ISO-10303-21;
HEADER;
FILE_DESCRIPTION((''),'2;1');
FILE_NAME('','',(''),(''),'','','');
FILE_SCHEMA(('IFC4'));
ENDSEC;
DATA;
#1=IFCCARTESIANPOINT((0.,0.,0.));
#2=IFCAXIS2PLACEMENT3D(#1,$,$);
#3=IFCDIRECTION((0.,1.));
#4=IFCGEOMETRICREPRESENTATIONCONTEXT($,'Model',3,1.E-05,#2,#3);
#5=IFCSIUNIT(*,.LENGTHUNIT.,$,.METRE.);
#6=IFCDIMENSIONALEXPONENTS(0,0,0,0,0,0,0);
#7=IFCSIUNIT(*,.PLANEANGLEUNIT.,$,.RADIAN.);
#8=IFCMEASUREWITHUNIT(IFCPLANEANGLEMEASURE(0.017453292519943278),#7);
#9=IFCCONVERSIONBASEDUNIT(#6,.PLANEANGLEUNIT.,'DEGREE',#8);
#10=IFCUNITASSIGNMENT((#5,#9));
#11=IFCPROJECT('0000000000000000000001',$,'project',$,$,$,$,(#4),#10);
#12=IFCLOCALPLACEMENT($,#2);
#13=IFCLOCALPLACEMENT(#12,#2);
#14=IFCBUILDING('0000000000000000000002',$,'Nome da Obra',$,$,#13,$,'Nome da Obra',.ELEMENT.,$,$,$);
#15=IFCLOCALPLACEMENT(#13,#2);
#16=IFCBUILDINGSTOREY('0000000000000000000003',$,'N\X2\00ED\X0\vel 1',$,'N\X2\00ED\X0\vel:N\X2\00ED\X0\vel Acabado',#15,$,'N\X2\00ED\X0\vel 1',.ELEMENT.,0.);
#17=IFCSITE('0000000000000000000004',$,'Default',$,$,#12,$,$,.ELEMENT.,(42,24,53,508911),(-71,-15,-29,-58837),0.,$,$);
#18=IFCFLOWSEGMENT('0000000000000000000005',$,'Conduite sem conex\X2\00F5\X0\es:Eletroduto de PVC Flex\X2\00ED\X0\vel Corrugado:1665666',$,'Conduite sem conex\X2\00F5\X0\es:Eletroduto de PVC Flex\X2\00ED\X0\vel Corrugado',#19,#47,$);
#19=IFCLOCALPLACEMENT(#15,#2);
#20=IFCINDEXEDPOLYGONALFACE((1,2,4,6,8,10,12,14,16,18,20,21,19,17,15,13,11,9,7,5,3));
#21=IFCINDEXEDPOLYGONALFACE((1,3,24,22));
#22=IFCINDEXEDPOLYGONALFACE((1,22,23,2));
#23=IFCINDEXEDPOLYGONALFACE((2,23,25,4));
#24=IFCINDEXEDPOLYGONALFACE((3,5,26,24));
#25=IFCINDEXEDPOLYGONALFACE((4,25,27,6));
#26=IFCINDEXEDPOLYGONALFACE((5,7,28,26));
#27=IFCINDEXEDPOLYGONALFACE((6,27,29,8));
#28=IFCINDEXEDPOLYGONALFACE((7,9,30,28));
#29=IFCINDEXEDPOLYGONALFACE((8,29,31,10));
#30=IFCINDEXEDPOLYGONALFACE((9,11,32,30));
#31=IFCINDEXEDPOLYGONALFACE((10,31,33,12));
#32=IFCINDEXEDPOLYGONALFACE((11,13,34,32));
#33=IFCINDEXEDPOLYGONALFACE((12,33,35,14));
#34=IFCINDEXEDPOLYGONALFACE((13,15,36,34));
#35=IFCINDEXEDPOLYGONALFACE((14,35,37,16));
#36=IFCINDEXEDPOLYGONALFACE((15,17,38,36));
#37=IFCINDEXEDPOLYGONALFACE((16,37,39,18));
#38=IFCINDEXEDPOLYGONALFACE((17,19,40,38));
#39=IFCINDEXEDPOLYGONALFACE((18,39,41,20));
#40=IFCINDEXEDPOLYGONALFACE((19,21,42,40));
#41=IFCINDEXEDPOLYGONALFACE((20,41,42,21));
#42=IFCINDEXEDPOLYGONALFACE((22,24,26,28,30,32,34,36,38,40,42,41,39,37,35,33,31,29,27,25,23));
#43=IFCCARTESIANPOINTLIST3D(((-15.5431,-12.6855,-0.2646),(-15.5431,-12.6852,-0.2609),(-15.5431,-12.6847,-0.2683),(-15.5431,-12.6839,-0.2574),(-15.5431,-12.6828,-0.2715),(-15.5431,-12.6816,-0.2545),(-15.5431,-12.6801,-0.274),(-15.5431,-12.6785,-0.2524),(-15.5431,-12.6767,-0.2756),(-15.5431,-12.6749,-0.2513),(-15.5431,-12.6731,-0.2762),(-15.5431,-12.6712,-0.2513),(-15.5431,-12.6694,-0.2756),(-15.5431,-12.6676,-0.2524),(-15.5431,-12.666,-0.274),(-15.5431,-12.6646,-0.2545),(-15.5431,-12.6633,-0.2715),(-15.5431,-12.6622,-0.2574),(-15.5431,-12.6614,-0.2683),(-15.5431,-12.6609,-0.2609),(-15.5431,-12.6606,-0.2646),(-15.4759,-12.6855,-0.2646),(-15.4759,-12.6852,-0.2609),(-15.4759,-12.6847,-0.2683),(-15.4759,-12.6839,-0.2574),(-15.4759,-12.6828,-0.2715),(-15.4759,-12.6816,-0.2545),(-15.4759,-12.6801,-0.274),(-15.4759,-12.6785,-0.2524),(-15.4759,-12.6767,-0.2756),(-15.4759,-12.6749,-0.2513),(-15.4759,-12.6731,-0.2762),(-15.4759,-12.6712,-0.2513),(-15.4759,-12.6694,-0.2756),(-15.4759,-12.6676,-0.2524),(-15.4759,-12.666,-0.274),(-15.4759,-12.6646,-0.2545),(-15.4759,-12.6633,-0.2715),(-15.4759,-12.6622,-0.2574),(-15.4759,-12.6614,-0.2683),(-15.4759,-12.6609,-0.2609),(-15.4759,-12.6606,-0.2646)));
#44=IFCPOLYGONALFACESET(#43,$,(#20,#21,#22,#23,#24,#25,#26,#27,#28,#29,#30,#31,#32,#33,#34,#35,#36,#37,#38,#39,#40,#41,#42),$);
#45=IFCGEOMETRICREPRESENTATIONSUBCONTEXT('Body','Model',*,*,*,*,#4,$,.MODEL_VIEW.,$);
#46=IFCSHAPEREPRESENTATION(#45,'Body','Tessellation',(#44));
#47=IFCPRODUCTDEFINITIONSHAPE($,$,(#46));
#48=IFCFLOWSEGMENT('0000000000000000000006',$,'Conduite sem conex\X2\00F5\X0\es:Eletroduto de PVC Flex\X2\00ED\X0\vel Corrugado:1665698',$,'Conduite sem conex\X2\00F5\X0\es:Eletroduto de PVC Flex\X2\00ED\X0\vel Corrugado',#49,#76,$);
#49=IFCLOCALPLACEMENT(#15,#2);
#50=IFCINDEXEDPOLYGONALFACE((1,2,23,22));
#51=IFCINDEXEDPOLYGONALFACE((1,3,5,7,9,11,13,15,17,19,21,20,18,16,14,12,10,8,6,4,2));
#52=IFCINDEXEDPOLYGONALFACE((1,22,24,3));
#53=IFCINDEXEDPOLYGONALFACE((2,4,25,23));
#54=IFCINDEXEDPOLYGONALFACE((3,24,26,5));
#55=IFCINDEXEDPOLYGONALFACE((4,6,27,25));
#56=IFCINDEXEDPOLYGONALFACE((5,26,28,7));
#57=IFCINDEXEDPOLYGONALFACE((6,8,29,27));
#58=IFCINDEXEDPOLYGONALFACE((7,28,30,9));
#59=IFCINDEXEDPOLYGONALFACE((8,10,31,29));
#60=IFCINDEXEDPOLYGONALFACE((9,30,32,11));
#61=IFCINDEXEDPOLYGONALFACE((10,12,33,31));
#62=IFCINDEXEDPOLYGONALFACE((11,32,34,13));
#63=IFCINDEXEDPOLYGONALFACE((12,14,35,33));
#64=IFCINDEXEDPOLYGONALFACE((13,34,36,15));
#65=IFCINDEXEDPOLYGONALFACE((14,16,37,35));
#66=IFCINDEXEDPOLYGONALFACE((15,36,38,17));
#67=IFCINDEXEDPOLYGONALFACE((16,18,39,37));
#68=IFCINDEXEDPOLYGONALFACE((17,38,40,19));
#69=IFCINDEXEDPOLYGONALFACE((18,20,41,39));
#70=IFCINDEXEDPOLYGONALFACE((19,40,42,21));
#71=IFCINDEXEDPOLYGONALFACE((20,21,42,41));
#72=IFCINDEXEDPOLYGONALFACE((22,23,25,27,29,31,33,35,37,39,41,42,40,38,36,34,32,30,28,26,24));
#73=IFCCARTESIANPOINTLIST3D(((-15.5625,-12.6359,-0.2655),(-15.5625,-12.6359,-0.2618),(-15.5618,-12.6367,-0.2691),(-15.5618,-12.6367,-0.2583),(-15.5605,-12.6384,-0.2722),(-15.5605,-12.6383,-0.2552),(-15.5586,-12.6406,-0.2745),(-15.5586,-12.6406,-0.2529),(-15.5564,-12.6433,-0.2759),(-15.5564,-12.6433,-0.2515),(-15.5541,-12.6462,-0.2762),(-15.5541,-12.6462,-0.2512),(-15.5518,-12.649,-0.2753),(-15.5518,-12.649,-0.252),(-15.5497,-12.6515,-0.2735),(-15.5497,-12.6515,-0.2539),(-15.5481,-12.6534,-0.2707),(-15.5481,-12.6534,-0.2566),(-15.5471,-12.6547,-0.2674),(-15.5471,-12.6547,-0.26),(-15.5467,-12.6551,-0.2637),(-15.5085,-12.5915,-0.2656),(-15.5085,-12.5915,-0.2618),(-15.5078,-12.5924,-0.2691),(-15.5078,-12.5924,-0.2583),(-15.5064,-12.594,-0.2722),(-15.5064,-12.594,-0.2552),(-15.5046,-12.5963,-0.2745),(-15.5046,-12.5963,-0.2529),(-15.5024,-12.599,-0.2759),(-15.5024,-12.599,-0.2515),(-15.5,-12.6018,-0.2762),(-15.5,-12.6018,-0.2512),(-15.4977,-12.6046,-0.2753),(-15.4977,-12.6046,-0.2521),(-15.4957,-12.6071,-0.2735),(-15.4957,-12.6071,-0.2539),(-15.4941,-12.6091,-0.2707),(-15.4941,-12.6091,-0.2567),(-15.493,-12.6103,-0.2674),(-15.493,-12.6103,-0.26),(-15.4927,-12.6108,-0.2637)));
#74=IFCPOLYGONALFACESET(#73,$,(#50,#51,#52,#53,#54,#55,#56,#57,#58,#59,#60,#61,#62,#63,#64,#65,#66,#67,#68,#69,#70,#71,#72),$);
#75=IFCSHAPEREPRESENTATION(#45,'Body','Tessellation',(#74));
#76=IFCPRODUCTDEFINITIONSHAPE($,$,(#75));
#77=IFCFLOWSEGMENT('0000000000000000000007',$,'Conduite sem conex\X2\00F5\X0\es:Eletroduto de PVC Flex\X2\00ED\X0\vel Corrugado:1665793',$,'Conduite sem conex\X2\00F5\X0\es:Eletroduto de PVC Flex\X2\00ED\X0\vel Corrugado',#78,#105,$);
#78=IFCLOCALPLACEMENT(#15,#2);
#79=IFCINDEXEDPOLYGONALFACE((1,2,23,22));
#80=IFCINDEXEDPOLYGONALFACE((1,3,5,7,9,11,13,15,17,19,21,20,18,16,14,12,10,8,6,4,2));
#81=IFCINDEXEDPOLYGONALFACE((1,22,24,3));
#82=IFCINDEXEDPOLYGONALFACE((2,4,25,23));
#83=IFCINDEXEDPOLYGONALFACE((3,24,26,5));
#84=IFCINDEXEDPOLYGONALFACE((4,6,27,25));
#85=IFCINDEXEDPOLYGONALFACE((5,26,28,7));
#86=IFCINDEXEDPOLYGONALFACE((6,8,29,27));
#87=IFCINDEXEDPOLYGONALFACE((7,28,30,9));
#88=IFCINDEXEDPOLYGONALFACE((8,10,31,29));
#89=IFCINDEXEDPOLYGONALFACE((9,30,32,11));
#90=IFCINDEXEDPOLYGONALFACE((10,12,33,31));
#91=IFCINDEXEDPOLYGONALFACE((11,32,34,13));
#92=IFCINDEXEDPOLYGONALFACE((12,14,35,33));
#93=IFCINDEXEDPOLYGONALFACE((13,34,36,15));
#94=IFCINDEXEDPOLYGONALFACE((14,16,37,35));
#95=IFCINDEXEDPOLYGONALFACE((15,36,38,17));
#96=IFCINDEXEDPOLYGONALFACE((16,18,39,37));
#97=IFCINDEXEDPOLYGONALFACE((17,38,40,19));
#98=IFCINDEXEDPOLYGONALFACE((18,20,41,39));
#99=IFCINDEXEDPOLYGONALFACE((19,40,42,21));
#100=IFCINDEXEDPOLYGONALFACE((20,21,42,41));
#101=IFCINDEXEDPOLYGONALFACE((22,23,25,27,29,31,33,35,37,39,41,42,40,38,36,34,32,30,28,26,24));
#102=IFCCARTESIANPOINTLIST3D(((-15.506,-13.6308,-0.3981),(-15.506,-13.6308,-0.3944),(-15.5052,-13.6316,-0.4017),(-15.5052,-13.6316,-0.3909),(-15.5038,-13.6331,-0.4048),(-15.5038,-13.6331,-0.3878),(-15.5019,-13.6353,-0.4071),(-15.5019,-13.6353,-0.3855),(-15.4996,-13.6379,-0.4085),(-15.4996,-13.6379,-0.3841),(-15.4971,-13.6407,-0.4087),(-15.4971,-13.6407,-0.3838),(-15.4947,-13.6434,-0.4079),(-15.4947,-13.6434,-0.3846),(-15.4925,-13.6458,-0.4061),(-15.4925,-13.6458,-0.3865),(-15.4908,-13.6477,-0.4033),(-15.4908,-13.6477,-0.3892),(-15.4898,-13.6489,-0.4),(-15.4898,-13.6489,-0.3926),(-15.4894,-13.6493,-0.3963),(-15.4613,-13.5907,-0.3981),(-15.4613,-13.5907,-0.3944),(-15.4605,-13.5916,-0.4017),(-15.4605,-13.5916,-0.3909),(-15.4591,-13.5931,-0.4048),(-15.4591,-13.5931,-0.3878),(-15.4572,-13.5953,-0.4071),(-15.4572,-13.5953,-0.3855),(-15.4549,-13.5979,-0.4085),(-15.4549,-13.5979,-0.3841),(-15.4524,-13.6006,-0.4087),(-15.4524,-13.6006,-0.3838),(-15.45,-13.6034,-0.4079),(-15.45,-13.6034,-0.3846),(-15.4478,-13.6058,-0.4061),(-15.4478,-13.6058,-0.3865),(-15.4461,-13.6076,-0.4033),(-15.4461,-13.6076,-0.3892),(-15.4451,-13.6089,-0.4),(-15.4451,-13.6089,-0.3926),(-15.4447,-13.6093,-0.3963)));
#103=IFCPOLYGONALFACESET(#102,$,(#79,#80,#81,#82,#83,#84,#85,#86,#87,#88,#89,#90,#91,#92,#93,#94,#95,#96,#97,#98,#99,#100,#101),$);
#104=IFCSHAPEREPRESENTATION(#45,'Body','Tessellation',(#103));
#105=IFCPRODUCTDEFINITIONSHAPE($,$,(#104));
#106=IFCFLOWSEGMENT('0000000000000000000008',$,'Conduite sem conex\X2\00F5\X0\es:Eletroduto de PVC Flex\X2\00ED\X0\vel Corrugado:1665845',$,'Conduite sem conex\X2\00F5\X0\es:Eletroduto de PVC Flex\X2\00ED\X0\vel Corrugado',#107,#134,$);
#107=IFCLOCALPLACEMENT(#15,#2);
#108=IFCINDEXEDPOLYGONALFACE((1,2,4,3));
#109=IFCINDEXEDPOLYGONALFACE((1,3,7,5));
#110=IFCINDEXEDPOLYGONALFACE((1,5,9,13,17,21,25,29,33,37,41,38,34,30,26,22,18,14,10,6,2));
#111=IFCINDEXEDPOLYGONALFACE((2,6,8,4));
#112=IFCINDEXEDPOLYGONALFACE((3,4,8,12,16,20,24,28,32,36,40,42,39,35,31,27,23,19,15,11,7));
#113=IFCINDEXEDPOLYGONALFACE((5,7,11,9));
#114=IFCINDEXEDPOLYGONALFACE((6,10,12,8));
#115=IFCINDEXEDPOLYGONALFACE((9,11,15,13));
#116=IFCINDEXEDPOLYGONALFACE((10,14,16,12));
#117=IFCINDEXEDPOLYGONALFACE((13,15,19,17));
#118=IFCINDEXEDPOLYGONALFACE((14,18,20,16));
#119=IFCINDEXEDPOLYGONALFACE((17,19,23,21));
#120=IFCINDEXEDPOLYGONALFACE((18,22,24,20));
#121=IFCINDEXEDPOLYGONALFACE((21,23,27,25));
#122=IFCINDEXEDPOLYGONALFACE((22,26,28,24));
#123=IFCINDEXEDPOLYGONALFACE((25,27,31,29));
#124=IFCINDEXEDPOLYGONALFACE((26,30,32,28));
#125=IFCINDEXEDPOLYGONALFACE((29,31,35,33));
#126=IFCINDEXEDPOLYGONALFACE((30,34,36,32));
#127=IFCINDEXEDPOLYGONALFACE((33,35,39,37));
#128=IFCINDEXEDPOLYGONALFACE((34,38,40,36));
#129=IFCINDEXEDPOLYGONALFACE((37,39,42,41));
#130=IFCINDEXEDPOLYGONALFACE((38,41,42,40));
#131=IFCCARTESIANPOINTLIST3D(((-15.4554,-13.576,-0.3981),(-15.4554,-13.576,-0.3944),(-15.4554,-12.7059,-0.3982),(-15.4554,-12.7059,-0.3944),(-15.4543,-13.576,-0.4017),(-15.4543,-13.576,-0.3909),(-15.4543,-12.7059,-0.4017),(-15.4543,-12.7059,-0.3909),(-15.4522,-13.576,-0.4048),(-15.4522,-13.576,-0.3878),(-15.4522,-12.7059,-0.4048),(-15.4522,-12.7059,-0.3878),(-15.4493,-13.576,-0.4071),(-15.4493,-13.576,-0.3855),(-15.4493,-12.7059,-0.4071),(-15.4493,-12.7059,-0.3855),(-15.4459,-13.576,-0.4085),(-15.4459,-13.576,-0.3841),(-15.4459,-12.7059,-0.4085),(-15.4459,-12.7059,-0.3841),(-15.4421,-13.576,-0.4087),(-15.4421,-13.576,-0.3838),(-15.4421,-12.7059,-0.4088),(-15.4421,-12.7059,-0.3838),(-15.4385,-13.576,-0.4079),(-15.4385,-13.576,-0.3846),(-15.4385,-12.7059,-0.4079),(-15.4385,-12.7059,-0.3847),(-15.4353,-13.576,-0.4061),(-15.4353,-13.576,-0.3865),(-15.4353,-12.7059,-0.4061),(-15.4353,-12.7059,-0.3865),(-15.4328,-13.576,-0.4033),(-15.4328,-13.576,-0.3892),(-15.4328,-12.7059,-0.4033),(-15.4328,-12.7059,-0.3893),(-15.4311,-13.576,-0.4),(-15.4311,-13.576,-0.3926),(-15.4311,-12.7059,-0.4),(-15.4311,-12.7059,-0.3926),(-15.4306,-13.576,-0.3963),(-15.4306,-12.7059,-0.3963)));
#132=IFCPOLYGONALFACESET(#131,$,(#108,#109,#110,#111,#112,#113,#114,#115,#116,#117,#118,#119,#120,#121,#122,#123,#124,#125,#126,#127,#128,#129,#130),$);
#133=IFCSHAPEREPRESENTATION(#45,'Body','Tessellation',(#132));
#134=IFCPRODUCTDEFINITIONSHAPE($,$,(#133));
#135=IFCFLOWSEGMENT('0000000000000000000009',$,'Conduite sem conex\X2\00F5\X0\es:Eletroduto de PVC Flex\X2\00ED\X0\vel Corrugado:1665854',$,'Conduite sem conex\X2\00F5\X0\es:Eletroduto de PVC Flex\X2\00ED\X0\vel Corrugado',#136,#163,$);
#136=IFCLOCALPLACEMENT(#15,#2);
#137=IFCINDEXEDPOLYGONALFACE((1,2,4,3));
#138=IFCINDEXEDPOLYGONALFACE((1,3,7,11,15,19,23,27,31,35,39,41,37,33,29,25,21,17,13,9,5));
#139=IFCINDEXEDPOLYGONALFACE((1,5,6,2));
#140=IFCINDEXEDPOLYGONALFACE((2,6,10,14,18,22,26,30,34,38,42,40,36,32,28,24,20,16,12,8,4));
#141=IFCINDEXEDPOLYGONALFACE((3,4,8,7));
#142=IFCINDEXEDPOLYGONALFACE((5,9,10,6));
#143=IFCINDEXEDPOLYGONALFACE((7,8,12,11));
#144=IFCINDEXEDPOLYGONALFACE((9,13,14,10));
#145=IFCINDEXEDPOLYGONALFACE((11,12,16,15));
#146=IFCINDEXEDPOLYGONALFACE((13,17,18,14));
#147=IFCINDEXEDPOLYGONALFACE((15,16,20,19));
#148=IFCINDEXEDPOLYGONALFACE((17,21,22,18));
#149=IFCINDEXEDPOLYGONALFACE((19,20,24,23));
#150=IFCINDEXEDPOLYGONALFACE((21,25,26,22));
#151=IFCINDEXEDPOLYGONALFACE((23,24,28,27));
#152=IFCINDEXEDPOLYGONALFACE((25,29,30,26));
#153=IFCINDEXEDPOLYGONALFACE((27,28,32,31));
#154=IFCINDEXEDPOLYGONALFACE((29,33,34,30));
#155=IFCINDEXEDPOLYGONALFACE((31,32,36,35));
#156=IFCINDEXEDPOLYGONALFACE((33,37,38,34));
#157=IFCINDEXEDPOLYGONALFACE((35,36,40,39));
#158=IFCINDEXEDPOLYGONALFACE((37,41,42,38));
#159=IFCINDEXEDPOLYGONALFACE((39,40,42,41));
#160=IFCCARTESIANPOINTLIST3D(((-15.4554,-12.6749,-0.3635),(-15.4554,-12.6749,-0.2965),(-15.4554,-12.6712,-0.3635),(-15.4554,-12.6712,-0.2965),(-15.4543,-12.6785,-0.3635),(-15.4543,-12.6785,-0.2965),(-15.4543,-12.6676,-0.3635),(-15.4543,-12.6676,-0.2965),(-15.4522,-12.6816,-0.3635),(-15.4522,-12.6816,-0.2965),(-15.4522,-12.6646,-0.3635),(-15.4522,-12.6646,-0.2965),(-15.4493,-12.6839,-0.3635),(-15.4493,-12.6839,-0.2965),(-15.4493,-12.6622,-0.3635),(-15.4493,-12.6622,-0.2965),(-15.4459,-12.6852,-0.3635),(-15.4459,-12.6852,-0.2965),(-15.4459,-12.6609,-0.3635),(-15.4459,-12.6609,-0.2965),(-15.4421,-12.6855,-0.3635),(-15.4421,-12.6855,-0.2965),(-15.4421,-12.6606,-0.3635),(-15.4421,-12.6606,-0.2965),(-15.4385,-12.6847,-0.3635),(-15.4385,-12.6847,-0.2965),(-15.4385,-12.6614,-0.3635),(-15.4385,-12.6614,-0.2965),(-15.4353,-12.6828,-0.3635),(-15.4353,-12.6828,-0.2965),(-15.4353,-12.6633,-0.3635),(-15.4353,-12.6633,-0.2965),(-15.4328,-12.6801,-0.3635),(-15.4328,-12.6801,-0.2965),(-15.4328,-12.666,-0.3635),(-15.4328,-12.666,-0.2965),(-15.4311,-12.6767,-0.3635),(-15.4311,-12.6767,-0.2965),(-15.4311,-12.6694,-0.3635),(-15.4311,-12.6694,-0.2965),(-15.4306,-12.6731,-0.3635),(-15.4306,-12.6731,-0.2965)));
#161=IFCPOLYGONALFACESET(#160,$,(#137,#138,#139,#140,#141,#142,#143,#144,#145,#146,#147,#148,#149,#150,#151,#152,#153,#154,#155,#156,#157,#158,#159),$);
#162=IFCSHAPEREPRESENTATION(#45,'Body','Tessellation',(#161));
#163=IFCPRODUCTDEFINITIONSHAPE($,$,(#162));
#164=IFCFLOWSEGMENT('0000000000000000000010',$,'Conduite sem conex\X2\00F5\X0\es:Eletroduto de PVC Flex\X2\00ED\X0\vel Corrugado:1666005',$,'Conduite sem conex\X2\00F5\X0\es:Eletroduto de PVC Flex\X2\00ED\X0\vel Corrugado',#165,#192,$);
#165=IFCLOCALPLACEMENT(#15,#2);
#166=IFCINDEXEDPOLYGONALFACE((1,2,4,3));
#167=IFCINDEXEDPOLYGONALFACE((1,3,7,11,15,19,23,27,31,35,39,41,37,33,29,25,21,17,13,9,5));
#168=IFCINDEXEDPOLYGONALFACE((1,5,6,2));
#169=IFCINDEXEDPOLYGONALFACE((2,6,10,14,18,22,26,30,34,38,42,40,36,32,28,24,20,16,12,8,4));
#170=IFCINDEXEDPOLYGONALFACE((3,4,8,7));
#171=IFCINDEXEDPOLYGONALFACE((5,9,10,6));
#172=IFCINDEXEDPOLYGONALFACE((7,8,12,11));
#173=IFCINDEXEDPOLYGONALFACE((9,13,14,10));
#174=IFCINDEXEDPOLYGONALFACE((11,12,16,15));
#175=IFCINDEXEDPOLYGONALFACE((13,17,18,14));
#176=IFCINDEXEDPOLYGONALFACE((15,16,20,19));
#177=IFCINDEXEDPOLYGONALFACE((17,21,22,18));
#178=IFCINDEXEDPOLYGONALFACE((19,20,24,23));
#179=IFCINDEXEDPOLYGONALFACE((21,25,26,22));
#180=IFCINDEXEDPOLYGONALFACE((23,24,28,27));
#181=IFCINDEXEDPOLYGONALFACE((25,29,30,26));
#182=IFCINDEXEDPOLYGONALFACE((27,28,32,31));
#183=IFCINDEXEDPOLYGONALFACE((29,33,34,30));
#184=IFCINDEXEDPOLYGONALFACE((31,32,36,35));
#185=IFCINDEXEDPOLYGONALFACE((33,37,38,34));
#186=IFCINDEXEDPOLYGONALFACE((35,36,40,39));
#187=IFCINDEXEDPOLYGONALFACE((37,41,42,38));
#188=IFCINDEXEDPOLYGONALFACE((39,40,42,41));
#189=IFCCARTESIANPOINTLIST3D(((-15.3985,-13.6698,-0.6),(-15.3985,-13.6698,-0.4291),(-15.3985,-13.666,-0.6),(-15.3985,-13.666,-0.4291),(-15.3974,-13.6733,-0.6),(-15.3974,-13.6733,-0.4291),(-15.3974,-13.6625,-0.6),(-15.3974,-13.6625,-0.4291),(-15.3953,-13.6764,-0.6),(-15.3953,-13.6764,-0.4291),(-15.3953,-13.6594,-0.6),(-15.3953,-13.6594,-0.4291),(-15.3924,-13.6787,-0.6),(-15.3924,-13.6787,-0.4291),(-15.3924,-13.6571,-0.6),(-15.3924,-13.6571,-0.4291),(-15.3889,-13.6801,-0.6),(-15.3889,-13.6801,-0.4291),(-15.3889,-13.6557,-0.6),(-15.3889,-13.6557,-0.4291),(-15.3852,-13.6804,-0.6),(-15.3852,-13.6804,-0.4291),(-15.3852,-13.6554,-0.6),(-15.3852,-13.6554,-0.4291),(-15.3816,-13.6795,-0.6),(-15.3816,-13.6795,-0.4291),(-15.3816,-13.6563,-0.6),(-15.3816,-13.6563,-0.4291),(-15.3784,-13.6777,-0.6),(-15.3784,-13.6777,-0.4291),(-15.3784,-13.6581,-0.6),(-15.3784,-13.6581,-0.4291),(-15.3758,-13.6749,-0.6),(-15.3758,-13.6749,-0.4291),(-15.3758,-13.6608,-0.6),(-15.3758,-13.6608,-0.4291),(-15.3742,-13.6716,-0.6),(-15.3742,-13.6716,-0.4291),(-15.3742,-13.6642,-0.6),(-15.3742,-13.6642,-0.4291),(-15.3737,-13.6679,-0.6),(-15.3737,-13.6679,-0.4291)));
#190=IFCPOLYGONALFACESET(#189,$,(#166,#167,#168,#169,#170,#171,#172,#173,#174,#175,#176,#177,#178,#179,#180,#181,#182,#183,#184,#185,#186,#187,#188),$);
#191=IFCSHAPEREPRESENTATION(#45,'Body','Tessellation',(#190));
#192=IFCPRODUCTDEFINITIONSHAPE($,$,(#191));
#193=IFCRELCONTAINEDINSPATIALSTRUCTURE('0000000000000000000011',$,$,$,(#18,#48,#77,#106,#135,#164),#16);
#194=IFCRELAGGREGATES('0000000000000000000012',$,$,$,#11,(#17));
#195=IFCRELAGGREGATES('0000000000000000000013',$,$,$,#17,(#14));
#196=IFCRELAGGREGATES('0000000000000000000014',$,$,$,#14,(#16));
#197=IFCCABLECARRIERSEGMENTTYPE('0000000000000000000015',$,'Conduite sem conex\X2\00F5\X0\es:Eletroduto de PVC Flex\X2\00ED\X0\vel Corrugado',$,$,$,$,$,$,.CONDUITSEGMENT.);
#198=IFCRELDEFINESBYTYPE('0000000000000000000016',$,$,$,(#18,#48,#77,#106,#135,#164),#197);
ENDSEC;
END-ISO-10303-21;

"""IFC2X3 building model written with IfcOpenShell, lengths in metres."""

from ifc_helpers import new_model, entity, si_unit, converted_unit, direction, frame, frame_2d, origin, origin_2d_with_axis, place, context, subcontext, project, spatial, circle, extrude, type_object, element, save


model = new_model("IFC2X3")

# Units and contexts
model_context = context("Model", 3, precision=1e-05, world=origin(), true_north=direction((0.0, 1.0)))
body_context = subcontext(model_context, "Body", "Model", "MODEL_VIEW")
ifc_project = project(units=[si_unit("LENGTHUNIT", "METRE"), converted_unit("PLANEANGLEUNIT", "DEGREE", entity("IfcPlaneAngleMeasure", 0.017453292519943278), si_unit("PLANEANGLEUNIT", "RADIAN"), dimensions=[0, 0, 0, 0, 0, 0, 0])], contexts=[model_context])

# Site, building, storey
site_placement = place(None, origin())
site = spatial("IfcSite", under=ifc_project, at=site_placement, Name="Default", CompositionType="ELEMENT", RefLatitude=(42, 24, 53, 508911), RefLongitude=(-71, -15, -29, -58837), RefElevation=0.0)
building_placement = place(site_placement, origin())
building = spatial("IfcBuilding", under=site, at=building_placement, Name="Nome da Obra", LongName="Nome da Obra", CompositionType="ELEMENT")
storey_placement = place(building_placement, origin())
storey = spatial("IfcBuildingStorey", under=building, at=storey_placement, Name="Nível 1", ObjectType="Nível:Nível Acabado", LongName="Nível 1", CompositionType="ELEMENT", Elevation=0.0)

# Flow segments
cable_carrier_segment_type = type_object("IfcCableCarrierSegmentType", Name="Conduite sem conexões:Eletroduto de PVC Flexível Corrugado", PredefinedType="CONDUITSEGMENT")
flow_segment_1_placement = place(storey_placement, origin())
element("IfcFlowSegment", 1, at=flow_segment_1_placement, inside=storey, type_object=cable_carrier_segment_type, Name="Conduite sem conexões:Eletroduto de PVC Flexível Corrugado:1665666", ObjectType="Conduite sem conexões:Eletroduto de PVC Flexível Corrugado", context=body_context, shape_type="SweptSolid", body=[
    extrude(circle(Radius=0.0125, at=frame_2d((0.0, 0.0), x_axis=(1.0, 0.0))), frame((-15.5431, -12.6731, -0.2637), z_axis=(1.0, 0.0, -0.000039), x_axis=(-0.000039, 0.0, -1.0)), (-0.000039, 0.0, 1.0), 0.0672),
])
flow_segment_2_placement = place(storey_placement, origin())
element("IfcFlowSegment", 2, at=flow_segment_2_placement, inside=storey, type_object=cable_carrier_segment_type, Name="Conduite sem conexões:Eletroduto de PVC Flexível Corrugado:1665698", ObjectType="Conduite sem conexões:Eletroduto de PVC Flexível Corrugado", context=body_context, shape_type="SweptSolid", body=[
    extrude(circle(Radius=0.0125, at=origin_2d_with_axis()), frame((-15.5006, -12.6011, -0.2637), z_axis=(-0.773061, -0.634332, 0.000196), x_axis=(0.634332, -0.773061, 0.0)), (0.0, 0.0, 1.0), 0.0699),
])
flow_segment_3_placement = place(storey_placement, origin())
element("IfcFlowSegment", 3, at=flow_segment_3_placement, inside=storey, type_object=cable_carrier_segment_type, Name="Conduite sem conexões:Eletroduto de PVC Flexível Corrugado:1665793", ObjectType="Conduite sem conexões:Eletroduto de PVC Flexível Corrugado", context=body_context, shape_type="SweptSolid", body=[
    extrude(circle(Radius=0.0125, at=origin_2d_with_axis()), frame((-15.4977, -13.64, -0.3963), z_axis=(0.745155, 0.666891, 0.0), x_axis=(0.666891, -0.745155, 0.0)), (0.0, 0.0, 1.0), 0.06),
])
flow_segment_4_placement = place(storey_placement, origin())
element("IfcFlowSegment", 4, at=flow_segment_4_placement, inside=storey, type_object=cable_carrier_segment_type, Name="Conduite sem conexões:Eletroduto de PVC Flexível Corrugado:1665845", ObjectType="Conduite sem conexões:Eletroduto de PVC Flexível Corrugado", context=body_context, shape_type="SweptSolid", body=[
    extrude(circle(Radius=0.0125, at=frame_2d((0.0, 0.0), x_axis=(1.0, 0.0))), frame((-15.4431, -12.7059, -0.3963), z_axis=(0.0, -1.0, 0.000021), x_axis=(1.0, 0.0, 0.0)), (0.0, 0.0, 1.0), 0.8701),
])
flow_segment_5_placement = place(storey_placement, origin())
element("IfcFlowSegment", 5, at=flow_segment_5_placement, inside=storey, type_object=cable_carrier_segment_type, Name="Conduite sem conexões:Eletroduto de PVC Flexível Corrugado:1665854", ObjectType="Conduite sem conexões:Eletroduto de PVC Flexível Corrugado", context=body_context, shape_type="SweptSolid", body=[
    extrude(circle(Radius=0.0125, at=origin_2d_with_axis()), frame((-15.4431, -12.6731, -0.3635)), (0.0, 0.0, 1.0), 0.067),
])
flow_segment_6_placement = place(storey_placement, origin())
element("IfcFlowSegment", 6, at=flow_segment_6_placement, inside=storey, type_object=cable_carrier_segment_type, Name="Conduite sem conexões:Eletroduto de PVC Flexível Corrugado:1666005", ObjectType="Conduite sem conexões:Eletroduto de PVC Flexível Corrugado", context=body_context, shape_type="SweptSolid", body=[
    extrude(circle(Radius=0.0125, at=frame_2d((0.0, 0.0), x_axis=(1.0, 0.0))), frame((-15.3862, -13.6679, -0.6)), (0.0, 0.0, 1.0), 0.171),
])

save(model, "model.ifc")
